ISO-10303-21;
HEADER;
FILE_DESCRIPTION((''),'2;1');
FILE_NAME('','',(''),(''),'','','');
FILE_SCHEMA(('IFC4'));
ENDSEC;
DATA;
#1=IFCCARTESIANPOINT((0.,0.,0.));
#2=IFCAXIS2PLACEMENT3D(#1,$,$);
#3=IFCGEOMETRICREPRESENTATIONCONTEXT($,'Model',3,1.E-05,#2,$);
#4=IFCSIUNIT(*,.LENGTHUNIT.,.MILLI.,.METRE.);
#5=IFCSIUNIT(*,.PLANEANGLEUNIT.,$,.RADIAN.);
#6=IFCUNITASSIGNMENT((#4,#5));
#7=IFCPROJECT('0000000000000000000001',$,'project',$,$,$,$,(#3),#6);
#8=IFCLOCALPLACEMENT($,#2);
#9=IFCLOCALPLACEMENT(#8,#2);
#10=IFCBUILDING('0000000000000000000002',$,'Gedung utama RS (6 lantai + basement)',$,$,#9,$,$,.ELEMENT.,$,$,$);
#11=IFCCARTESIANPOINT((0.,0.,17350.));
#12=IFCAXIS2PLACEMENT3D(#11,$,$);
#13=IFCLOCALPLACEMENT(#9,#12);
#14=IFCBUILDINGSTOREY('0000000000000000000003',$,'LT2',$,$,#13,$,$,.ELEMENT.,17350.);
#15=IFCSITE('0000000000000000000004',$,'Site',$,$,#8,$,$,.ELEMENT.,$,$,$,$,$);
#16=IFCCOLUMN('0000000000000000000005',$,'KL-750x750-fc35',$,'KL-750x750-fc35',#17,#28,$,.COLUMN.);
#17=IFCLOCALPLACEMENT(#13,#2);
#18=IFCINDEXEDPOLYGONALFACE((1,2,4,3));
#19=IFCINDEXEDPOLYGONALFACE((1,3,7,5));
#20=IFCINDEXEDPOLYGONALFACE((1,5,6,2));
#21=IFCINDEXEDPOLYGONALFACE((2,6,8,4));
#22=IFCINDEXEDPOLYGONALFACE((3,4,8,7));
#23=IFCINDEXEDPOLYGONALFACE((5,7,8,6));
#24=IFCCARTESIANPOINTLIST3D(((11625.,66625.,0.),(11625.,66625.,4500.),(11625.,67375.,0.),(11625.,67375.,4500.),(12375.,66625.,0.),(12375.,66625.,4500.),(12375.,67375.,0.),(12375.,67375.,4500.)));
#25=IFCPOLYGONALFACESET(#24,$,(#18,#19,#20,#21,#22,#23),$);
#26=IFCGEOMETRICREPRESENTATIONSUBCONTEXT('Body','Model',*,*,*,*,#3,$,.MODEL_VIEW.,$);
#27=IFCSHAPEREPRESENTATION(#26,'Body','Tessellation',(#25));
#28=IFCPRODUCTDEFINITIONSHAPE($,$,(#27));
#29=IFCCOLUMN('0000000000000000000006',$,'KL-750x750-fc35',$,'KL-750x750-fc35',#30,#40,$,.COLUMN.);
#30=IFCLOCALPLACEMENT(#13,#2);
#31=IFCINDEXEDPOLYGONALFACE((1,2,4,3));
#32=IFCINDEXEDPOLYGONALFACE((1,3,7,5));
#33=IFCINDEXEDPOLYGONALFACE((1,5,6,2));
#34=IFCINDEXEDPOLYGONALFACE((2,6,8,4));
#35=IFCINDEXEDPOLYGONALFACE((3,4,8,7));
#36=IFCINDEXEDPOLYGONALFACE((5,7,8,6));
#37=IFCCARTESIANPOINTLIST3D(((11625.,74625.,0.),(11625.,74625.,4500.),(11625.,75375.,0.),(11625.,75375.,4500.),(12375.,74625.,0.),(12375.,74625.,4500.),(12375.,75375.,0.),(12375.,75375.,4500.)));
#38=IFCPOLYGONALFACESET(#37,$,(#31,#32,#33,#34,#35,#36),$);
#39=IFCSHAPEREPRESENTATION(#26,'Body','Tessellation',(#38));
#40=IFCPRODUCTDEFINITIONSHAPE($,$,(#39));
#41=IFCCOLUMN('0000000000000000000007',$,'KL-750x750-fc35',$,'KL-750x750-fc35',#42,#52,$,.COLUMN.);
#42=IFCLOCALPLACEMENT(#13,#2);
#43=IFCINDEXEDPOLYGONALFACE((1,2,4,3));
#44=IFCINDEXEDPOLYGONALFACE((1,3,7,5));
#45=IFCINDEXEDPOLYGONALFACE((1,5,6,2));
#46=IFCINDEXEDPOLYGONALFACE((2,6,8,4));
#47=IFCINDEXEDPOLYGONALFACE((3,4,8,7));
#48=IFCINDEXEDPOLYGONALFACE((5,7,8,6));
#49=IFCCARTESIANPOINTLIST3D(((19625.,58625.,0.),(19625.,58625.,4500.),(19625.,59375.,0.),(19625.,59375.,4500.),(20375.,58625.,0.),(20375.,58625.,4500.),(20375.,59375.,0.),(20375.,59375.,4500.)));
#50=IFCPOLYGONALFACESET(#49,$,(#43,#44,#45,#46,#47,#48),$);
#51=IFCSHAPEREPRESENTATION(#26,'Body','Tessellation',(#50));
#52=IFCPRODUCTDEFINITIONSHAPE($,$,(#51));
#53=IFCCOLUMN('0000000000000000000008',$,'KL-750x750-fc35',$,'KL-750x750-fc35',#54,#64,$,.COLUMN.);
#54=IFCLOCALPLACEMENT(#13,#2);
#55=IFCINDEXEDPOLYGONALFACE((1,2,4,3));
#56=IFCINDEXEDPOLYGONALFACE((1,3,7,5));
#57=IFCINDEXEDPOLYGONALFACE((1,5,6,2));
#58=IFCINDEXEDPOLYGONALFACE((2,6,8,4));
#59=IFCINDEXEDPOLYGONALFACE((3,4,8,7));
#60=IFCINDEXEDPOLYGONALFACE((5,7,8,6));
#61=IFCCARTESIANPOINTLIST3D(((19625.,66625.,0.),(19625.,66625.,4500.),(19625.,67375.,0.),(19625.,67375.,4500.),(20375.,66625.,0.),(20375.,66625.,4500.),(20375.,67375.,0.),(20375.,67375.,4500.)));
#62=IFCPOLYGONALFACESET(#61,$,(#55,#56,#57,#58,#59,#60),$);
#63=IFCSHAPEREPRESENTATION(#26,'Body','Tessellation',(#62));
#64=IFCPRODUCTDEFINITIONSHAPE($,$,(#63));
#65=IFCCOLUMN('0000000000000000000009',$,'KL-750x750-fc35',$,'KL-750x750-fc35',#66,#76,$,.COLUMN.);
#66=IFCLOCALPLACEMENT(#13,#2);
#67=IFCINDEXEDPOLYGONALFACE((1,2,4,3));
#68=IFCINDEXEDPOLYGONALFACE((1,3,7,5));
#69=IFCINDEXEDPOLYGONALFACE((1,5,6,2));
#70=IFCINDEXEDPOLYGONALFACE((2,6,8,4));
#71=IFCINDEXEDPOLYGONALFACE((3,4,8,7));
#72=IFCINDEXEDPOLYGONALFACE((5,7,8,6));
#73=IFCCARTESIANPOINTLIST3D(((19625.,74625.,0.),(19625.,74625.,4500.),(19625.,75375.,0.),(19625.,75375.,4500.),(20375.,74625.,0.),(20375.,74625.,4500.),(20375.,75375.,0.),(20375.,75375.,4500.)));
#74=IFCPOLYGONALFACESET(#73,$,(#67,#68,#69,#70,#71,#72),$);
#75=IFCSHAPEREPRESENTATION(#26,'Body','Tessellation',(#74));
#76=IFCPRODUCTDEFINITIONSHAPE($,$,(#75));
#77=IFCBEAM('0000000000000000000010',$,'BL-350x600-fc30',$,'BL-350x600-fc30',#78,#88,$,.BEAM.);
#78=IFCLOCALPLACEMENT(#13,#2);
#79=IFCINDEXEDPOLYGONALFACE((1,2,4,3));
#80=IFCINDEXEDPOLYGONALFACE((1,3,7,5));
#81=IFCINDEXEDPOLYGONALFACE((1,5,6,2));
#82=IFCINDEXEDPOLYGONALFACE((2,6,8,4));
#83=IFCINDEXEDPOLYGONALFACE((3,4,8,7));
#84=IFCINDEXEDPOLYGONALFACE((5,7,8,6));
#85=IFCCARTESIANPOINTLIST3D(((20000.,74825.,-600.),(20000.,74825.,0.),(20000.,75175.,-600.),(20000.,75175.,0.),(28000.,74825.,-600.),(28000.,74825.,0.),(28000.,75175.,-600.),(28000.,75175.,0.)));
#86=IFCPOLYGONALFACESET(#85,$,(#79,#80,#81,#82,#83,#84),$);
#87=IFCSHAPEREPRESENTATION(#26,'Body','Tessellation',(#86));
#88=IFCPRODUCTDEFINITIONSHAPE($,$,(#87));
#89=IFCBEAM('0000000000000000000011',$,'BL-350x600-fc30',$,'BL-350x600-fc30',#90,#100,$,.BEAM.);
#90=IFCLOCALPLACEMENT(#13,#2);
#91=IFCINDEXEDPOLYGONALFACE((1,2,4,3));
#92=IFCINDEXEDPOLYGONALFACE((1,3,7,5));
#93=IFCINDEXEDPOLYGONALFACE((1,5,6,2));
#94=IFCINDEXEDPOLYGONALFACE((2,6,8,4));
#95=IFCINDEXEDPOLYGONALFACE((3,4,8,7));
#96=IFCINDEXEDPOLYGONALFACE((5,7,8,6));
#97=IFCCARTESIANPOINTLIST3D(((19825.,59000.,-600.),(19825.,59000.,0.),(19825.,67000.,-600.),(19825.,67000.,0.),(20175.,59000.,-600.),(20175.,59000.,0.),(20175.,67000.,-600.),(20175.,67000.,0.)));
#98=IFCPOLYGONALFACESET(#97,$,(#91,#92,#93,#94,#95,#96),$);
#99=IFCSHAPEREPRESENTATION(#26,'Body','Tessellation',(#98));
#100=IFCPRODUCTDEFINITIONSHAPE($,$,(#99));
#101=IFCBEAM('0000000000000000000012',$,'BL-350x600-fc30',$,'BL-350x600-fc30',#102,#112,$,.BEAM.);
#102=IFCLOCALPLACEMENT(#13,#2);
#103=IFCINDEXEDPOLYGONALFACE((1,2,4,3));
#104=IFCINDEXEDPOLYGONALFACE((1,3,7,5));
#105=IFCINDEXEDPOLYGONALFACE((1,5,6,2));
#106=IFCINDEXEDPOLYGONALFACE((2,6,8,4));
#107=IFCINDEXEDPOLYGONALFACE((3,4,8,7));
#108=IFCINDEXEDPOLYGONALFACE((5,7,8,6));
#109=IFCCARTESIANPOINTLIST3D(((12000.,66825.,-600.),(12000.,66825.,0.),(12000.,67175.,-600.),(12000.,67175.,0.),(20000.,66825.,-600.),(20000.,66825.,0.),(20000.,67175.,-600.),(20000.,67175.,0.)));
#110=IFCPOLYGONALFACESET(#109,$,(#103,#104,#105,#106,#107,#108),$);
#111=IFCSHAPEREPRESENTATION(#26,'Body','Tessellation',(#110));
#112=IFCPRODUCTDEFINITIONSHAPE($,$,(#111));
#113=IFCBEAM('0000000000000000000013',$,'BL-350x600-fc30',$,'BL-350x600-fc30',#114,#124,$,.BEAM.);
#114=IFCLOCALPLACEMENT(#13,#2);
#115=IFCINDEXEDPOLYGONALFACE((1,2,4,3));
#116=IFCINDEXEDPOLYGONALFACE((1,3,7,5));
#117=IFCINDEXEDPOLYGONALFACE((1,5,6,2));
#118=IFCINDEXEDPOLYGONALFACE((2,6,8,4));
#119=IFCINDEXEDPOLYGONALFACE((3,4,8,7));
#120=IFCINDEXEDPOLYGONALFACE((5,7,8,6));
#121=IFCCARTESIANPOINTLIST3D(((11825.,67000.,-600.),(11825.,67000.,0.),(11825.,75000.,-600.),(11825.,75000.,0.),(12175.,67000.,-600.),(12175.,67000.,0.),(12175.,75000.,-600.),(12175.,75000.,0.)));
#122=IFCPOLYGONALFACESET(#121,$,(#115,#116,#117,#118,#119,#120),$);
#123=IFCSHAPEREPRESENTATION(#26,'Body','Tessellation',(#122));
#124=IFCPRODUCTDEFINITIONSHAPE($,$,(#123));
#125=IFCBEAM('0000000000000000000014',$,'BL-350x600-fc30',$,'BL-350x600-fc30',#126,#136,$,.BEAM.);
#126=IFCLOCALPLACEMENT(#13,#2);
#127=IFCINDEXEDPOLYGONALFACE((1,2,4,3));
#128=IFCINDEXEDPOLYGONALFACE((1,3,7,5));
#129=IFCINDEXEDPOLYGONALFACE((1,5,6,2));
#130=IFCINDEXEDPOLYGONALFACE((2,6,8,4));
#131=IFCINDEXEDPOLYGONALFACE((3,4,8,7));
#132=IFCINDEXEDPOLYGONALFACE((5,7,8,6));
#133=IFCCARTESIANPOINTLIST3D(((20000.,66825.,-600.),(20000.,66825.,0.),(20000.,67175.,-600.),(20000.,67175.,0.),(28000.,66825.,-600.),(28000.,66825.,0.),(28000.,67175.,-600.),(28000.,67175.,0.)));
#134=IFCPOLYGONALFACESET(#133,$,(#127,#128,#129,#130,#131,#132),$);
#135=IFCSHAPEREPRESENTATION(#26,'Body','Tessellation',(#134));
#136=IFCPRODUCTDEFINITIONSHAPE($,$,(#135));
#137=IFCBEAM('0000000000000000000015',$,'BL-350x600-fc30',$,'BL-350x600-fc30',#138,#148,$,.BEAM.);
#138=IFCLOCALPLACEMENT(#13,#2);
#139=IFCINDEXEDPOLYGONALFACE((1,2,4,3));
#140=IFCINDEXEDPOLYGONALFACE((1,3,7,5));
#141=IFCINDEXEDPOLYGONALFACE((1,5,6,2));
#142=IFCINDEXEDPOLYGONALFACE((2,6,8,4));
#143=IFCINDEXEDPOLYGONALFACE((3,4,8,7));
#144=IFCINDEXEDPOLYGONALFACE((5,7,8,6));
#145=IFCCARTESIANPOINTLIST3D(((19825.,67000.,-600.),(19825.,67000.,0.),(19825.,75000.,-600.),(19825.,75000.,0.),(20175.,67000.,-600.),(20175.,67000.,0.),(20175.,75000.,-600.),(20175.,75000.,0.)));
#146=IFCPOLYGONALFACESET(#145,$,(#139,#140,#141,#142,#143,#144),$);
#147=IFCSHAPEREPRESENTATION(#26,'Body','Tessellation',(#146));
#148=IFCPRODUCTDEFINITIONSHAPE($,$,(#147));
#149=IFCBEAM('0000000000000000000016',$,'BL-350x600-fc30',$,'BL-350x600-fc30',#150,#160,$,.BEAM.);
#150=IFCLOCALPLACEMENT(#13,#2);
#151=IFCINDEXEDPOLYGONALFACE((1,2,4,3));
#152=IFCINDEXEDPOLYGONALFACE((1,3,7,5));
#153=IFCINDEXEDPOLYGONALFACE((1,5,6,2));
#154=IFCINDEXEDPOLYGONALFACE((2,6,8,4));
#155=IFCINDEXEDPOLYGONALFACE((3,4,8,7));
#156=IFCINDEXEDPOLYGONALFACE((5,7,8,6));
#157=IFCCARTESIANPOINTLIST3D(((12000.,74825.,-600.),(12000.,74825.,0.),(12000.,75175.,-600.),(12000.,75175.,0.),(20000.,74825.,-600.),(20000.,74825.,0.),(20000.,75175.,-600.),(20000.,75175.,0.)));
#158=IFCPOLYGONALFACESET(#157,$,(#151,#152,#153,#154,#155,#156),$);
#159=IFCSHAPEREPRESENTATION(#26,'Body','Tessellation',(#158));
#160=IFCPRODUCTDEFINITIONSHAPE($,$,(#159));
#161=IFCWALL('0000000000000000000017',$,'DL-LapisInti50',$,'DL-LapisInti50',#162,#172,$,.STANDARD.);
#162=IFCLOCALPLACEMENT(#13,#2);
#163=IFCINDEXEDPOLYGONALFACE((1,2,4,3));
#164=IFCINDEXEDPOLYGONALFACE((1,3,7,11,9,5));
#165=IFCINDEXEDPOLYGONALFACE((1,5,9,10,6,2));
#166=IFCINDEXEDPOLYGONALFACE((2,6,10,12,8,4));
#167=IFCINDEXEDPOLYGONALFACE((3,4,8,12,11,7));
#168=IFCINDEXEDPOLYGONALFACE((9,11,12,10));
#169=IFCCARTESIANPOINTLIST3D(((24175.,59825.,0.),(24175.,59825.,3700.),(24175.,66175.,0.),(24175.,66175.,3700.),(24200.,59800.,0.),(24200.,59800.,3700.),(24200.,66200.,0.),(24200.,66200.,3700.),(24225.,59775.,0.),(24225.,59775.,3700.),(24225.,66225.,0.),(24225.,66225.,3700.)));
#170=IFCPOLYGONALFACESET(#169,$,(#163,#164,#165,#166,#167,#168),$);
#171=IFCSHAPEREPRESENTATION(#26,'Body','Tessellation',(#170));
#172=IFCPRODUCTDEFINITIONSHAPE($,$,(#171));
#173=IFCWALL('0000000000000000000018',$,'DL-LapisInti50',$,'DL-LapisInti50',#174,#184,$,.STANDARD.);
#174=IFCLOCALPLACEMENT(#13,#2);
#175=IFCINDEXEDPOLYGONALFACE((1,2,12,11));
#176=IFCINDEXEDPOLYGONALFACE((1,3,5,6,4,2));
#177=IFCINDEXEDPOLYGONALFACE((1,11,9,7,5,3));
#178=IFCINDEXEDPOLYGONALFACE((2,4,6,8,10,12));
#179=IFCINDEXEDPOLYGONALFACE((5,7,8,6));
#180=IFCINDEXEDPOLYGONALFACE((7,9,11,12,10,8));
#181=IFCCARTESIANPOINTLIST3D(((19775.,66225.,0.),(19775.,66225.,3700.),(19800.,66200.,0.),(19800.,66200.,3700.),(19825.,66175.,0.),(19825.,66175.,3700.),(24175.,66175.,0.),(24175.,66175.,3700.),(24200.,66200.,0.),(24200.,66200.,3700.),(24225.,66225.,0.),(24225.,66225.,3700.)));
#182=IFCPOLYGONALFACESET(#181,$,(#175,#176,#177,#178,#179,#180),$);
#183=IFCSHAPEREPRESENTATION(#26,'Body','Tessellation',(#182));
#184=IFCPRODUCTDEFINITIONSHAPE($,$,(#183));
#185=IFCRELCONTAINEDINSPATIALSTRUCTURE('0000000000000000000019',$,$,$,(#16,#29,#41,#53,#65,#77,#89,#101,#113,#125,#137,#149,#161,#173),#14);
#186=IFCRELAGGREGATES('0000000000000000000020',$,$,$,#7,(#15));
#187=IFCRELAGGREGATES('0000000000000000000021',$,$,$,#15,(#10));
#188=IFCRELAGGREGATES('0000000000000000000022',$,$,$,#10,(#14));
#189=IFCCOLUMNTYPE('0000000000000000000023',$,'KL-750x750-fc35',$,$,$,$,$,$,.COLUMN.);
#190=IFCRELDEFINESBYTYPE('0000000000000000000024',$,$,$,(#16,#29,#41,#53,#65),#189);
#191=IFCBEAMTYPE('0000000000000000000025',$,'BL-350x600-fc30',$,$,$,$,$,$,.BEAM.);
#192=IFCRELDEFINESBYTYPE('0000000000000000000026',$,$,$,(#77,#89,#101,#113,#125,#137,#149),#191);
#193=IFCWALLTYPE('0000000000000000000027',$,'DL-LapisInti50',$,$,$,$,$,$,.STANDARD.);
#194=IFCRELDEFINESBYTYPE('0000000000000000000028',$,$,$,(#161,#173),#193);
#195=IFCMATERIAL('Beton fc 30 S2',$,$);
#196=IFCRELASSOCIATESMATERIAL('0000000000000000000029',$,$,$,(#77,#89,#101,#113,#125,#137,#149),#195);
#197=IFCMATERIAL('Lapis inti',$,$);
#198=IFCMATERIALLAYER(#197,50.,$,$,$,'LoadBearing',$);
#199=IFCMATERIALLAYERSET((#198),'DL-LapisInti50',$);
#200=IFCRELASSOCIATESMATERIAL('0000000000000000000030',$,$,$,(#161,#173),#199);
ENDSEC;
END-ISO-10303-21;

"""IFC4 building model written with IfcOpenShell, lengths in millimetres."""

from ifc_helpers import new_model, si_unit, frame, origin, origin_2d, place, context, subcontext, project, spatial, polyline, rectangle, outline, extrude, material, layer, layer_set, layer_usage, material_profile, profile_set, profile_usage, type_object, element, save


model = new_model("IFC4")

# Units and contexts
model_context = context("Model", 3, precision=1e-05, world=origin())
body_context = subcontext(model_context, "Body", "Model", "MODEL_VIEW")
ifc_project = project(units=[si_unit("LENGTHUNIT", "METRE", prefix="MILLI"), si_unit("PLANEANGLEUNIT", "RADIAN")], contexts=[model_context])

# Site, building, storey
site_placement = place(None, origin())
site = spatial("IfcSite", under=ifc_project, at=site_placement, Name="Site", CompositionType="ELEMENT")
building_placement = place(site_placement, origin())
building = spatial("IfcBuilding", under=site, at=building_placement, Name="Gedung utama RS (6 lantai + basement)", CompositionType="ELEMENT")
storey_placement = place(building_placement, frame((0.0, 0.0, 17350.0)))
storey = spatial("IfcBuildingStorey", under=building, at=storey_placement, Name="LT2", CompositionType="ELEMENT", Elevation=17350.0)

# Columns
ifc_material_profile_1 = material_profile(None, rectangle(XDim=750.0, YDim=750.0, at=origin_2d()), Name="KL-750x750-fc35")
ifc_profile_set_1 = profile_set([ifc_material_profile_1], Name="KL-750x750-fc35")
ifc_profile_usage_1 = profile_usage(ifc_profile_set_1, cardinal=5)
column_type = type_object("IfcColumnType", Name="KL-750x750-fc35", PredefinedType="COLUMN")
for number, where, z_axis, x_axis, name in (
    (1, (12000.0, 67000.0, 0.0), (0.0, 0.0, 1.0), (1.0, 0.0, 0.0), "KL-750x750-fc35"),
    (2, (12000.0, 75000.0, 0.0), (0.0, 0.0, 1.0), (1.0, 0.0, 0.0), "KL-750x750-fc35"),
    (3, (20000.0, 59000.0, 0.0), (0.0, 0.0, 1.0), (1.0, 0.0, 0.0), "KL-750x750-fc35"),
    (4, (20000.0, 67000.0, 0.0), (0.0, 0.0, 1.0), (1.0, 0.0, 0.0), "KL-750x750-fc35"),
    (5, (20000.0, 75000.0, 0.0), (0.0, 0.0, 1.0), (1.0, 0.0, 0.0), "KL-750x750-fc35"),
):
    element("IfcColumn", number, at=place(storey_placement, frame(where, z_axis=z_axis, x_axis=x_axis)), inside=storey, type_object=column_type, material=ifc_profile_usage_1, Name=name, ObjectType="KL-750x750-fc35", PredefinedType="COLUMN", context=body_context, shape_type="SweptSolid", body=[
        extrude(rectangle(XDim=750.0, YDim=750.0, at=origin_2d()), origin(), (0.0, 0.0, 1.0), 4500.0),
    ])

# Beams
ifc_material_1 = material(Name="Beton fc 30 S2")
ifc_material_profile_2 = material_profile(ifc_material_1, rectangle(XDim=350.0, YDim=600.0, at=origin_2d()), Name="BL-350x600-fc30")
ifc_profile_set_2 = profile_set([ifc_material_profile_2], Name="BL-350x600-fc30")
ifc_profile_usage_2 = profile_usage(ifc_profile_set_2, cardinal=8)
beam_type = type_object("IfcBeamType", Name="BL-350x600-fc30", PredefinedType="BEAM")
beam_1_placement = place(storey_placement, frame((20000.0, 75000.0, -300.0)))
element("IfcBeam", 6, at=beam_1_placement, inside=storey, type_object=beam_type, material=ifc_profile_usage_2, Name="BL-350x600-fc30", ObjectType="BL-350x600-fc30", PredefinedType="BEAM", context=body_context, shape_type="SweptSolid", body=[
    extrude(rectangle(XDim=350.0, YDim=600.0, at=origin_2d()), frame((0.0, 0.0, 0.0), z_axis=(1.0, 0.0, 0.0), x_axis=(0.0, 1.0, 0.0)), (0.0, 0.0, 1.0), 8000.0),
])
beam_2_placement = place(storey_placement, frame((20000.0, 59000.0, -300.0)))
element("IfcBeam", 7, at=beam_2_placement, inside=storey, type_object=beam_type, material=ifc_profile_usage_2, Name="BL-350x600-fc30", ObjectType="BL-350x600-fc30", PredefinedType="BEAM", context=body_context, shape_type="SweptSolid", body=[
    extrude(rectangle(XDim=350.0, YDim=600.0, at=origin_2d()), frame((0.0, 0.0, 0.0), z_axis=(0.0, 1.0, 0.0), x_axis=(-1.0, 0.0, 0.0)), (0.0, 0.0, 1.0), 8000.0),
])
beam_3_placement = place(storey_placement, frame((12000.0, 67000.0, -300.0)))
element("IfcBeam", 8, at=beam_3_placement, inside=storey, type_object=beam_type, material=ifc_profile_usage_2, Name="BL-350x600-fc30", ObjectType="BL-350x600-fc30", PredefinedType="BEAM", context=body_context, shape_type="SweptSolid", body=[
    extrude(rectangle(XDim=350.0, YDim=600.0, at=origin_2d()), frame((0.0, 0.0, 0.0), z_axis=(1.0, 0.0, 0.0), x_axis=(0.0, 1.0, 0.0)), (0.0, 0.0, 1.0), 8000.0),
])
beam_4_placement = place(storey_placement, frame((12000.0, 67000.0, -300.0)))
element("IfcBeam", 9, at=beam_4_placement, inside=storey, type_object=beam_type, material=ifc_profile_usage_2, Name="BL-350x600-fc30", ObjectType="BL-350x600-fc30", PredefinedType="BEAM", context=body_context, shape_type="SweptSolid", body=[
    extrude(rectangle(XDim=350.0, YDim=600.0, at=origin_2d()), frame((0.0, 0.0, 0.0), z_axis=(0.0, 1.0, 0.0), x_axis=(-1.0, 0.0, 0.0)), (0.0, 0.0, 1.0), 8000.0),
])
beam_5_placement = place(storey_placement, frame((20000.0, 67000.0, -300.0)))
element("IfcBeam", 10, at=beam_5_placement, inside=storey, type_object=beam_type, material=ifc_profile_usage_2, Name="BL-350x600-fc30", ObjectType="BL-350x600-fc30", PredefinedType="BEAM", context=body_context, shape_type="SweptSolid", body=[
    extrude(rectangle(XDim=350.0, YDim=600.0, at=origin_2d()), frame((0.0, 0.0, 0.0), z_axis=(1.0, 0.0, 0.0), x_axis=(0.0, 1.0, 0.0)), (0.0, 0.0, 1.0), 8000.0),
])
beam_6_placement = place(storey_placement, frame((20000.0, 67000.0, -300.0)))
element("IfcBeam", 11, at=beam_6_placement, inside=storey, type_object=beam_type, material=ifc_profile_usage_2, Name="BL-350x600-fc30", ObjectType="BL-350x600-fc30", PredefinedType="BEAM", context=body_context, shape_type="SweptSolid", body=[
    extrude(rectangle(XDim=350.0, YDim=600.0, at=origin_2d()), frame((0.0, 0.0, 0.0), z_axis=(0.0, 1.0, 0.0), x_axis=(-1.0, 0.0, 0.0)), (0.0, 0.0, 1.0), 8000.0),
])
beam_7_placement = place(storey_placement, frame((12000.0, 75000.0, -300.0)))
element("IfcBeam", 12, at=beam_7_placement, inside=storey, type_object=beam_type, material=ifc_profile_usage_2, Name="BL-350x600-fc30", ObjectType="BL-350x600-fc30", PredefinedType="BEAM", context=body_context, shape_type="SweptSolid", body=[
    extrude(rectangle(XDim=350.0, YDim=600.0, at=origin_2d()), frame((0.0, 0.0, 0.0), z_axis=(1.0, 0.0, 0.0), x_axis=(0.0, 1.0, 0.0)), (0.0, 0.0, 1.0), 8000.0),
])

# Walls
ifc_material_2 = material(Name="Lapis inti")
ifc_layer_1 = layer(ifc_material_2, 50.0, Category="LoadBearing")
ifc_layer_set_1 = layer_set([ifc_layer_1], Name="DL-LapisInti50")
ifc_layer_usage_1 = layer_usage(ifc_layer_set_1, "AXIS2", "NEGATIVE", 25.0)
wall_type_1 = type_object("IfcWallType", Name="DL-LapisInti50", PredefinedType="STANDARD")
wall_1_placement = place(storey_placement, frame((24200.0, 59800.0, 0.0), z_axis=(0.0, 0.0, 1.0), x_axis=(0.0, 1.0, 0.0)))
element("IfcWall", 13, at=wall_1_placement, inside=storey, type_object=wall_type_1, material=ifc_layer_usage_1, Name="DL-LapisInti50", ObjectType="DL-LapisInti50", PredefinedType="STANDARD", context=body_context, shape_type="SweptSolid", body=[
    extrude(outline(polyline([(-25.0, -25.0), (0.0, 0.0), (25.0, 25.0), (6375.0, 25.0), (6400.0, 0.0), (6425.0, -25.0), (-25.0, -25.0)])), origin(), (0.0, 0.0, 1.0), 3700.0),
])
wall_2_placement = place(storey_placement, frame((24200.0, 66200.0, 0.0), z_axis=(0.0, 0.0, 1.0), x_axis=(-1.0, 0.0, 0.0)))
element("IfcWall", 14, at=wall_2_placement, inside=storey, type_object=wall_type_1, material=ifc_layer_usage_1, Name="DL-LapisInti50", ObjectType="DL-LapisInti50", PredefinedType="STANDARD", context=body_context, shape_type="SweptSolid", body=[
    extrude(outline(polyline([(-25.0, -25.0), (0.0, 0.0), (25.0, 25.0), (4375.0, 25.0), (4400.0, 0.0), (4425.0, -25.0), (-25.0, -25.0)])), origin(), (0.0, 0.0, 1.0), 3700.0),
])

save(model, "model.ifc")
